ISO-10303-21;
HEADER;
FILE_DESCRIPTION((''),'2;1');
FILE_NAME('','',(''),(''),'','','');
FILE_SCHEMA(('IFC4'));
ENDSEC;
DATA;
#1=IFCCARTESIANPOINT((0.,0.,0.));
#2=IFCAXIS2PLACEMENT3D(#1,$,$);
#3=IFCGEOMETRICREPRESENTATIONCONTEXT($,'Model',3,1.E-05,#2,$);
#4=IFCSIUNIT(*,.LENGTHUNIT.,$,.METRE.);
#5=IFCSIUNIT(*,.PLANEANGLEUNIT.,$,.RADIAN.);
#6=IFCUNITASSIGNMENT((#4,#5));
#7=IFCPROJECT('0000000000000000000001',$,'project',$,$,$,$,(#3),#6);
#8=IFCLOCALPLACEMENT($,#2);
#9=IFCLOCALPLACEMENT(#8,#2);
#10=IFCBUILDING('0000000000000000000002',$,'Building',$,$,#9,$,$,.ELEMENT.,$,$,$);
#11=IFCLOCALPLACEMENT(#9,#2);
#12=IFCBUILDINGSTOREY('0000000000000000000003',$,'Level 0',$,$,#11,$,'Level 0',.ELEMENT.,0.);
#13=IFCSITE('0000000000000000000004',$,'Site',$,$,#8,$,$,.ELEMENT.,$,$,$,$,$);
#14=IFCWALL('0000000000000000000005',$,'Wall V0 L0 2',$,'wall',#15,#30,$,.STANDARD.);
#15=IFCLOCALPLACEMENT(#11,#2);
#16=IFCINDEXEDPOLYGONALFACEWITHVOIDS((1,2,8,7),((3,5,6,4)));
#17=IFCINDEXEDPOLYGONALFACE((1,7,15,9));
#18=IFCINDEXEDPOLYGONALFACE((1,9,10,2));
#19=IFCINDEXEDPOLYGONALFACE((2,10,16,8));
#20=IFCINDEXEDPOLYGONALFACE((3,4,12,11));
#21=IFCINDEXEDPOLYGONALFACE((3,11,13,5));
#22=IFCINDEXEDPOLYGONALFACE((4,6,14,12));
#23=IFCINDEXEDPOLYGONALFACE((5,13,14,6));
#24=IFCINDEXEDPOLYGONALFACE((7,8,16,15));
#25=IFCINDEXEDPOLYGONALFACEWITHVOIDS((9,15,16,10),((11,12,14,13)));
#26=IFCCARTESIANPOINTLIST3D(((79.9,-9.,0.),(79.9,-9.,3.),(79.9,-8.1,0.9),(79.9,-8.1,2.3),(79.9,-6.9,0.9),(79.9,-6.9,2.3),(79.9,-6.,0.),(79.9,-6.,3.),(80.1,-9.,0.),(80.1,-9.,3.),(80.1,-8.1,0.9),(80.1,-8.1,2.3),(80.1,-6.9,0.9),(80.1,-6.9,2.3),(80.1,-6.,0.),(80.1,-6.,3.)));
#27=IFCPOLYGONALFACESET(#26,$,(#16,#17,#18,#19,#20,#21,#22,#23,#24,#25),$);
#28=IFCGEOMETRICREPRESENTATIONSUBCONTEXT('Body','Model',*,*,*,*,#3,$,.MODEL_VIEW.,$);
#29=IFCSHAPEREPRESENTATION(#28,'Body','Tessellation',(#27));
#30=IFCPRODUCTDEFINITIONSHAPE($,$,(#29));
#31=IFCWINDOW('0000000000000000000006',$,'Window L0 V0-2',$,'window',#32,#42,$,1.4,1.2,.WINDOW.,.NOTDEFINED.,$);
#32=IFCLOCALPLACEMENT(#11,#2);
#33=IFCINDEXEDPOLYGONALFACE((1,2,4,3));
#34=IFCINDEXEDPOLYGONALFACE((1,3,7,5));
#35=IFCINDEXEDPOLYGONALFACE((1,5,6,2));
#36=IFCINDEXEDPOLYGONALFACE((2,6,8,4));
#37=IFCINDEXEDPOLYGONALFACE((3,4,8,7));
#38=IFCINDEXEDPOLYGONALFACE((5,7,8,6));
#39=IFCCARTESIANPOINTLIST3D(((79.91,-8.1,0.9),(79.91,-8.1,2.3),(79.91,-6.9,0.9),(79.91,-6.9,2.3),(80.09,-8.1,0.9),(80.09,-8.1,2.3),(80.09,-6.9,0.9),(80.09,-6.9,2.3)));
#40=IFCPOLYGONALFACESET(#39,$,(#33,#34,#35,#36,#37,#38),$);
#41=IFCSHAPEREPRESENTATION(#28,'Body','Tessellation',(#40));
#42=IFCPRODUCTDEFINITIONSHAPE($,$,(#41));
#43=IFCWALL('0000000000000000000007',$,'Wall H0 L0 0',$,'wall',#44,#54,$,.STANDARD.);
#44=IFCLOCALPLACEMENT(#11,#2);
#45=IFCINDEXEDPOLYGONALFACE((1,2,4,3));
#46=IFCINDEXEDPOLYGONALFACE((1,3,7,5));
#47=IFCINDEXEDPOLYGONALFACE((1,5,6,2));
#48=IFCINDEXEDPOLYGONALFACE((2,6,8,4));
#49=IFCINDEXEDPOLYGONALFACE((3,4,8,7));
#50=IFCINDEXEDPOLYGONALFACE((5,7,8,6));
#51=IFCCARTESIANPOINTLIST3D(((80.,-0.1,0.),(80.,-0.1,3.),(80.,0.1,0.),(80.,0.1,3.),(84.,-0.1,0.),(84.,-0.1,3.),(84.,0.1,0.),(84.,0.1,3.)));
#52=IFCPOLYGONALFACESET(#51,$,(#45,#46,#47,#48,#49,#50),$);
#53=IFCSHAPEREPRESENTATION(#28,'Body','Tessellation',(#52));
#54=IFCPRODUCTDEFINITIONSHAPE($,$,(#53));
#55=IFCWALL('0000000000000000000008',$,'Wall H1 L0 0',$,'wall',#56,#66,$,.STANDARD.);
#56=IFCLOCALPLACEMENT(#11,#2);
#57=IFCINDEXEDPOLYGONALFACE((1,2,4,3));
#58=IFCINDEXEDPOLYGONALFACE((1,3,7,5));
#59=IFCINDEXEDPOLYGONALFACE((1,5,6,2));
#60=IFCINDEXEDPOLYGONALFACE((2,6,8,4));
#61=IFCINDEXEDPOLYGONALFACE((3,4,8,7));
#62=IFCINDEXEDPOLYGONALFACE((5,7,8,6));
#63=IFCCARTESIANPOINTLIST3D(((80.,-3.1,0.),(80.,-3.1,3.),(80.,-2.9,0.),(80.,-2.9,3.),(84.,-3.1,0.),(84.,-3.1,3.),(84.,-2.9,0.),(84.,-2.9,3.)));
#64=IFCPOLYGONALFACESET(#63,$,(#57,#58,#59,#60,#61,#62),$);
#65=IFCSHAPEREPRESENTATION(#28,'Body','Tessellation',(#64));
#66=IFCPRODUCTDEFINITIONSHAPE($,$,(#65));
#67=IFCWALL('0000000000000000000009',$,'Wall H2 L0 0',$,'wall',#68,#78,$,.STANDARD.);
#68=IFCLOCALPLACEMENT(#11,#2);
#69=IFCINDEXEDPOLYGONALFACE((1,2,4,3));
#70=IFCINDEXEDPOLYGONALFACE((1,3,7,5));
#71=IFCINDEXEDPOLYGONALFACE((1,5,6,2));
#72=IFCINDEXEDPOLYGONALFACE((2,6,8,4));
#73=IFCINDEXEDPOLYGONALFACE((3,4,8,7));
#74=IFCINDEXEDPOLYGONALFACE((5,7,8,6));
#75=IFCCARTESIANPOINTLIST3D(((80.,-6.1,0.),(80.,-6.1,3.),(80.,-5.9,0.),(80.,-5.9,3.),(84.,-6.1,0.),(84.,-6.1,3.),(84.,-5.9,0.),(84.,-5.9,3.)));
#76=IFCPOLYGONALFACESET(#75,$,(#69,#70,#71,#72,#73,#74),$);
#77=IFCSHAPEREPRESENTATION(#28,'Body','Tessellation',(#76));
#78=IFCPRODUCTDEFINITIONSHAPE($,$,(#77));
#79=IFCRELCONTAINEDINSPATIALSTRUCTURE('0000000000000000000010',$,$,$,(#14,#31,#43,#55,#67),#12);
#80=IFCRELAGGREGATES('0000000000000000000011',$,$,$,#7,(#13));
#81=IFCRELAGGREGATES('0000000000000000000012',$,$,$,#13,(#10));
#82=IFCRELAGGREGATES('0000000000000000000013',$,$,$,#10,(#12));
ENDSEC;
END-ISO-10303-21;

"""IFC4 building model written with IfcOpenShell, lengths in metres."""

from ifc_helpers import new_model, si_unit, frame, frame_2d, origin, origin_2d, place, context, subcontext, project, spatial, rectangle, extrude, element, fill, save


model = new_model("IFC4")

# Units and contexts
model_context = context("Model", 3, precision=1e-05, world=origin())
body_context = subcontext(model_context, "Body", "Model", "MODEL_VIEW")
ifc_project = project(units=[si_unit("LENGTHUNIT", "METRE"), si_unit("PLANEANGLEUNIT", "RADIAN")], contexts=[model_context])

# Site, building, storey
site_placement = place(None, origin())
site = spatial("IfcSite", under=ifc_project, at=site_placement, Name="Site", CompositionType="ELEMENT")
building_placement = place(site_placement, origin())
building = spatial("IfcBuilding", under=site, at=building_placement, Name="Building", CompositionType="ELEMENT")
storey_placement = place(building_placement, origin())
storey = spatial("IfcBuildingStorey", under=building, at=storey_placement, Name="Level 0", LongName="Level 0", CompositionType="ELEMENT", Elevation=0.0)

# Wall, opening, window
wall_1_placement = place(storey_placement, frame((80.0, -6.0, 0.0), z_axis=(0.0, 0.0, 1.0), x_axis=(0.0, -1.0, 0.0)))
wall_1 = element("IfcWall", 1, at=wall_1_placement, inside=storey, Name="Wall V0 L0 2", ObjectType="wall", PredefinedType="STANDARD", context=body_context, shape_type="SweptSolid", body=[
    extrude(rectangle(XDim=3.0, YDim=0.2, at=frame_2d((1.5, 0.0))), origin(), (0.0, 0.0, 1.0), 3.0),
])
opening_1_placement = place(storey_placement, frame((80.0, -7.5, 0.9), z_axis=(0.0, 0.0, 1.0), x_axis=(0.0, -1.0, 0.0)))
opening_1 = element("IfcOpeningElement", 2, at=opening_1_placement, cuts=wall_1, ObjectType="Opening", PredefinedType="OPENING", context=body_context, shape_type="SweptSolid", body=[
    extrude(rectangle(XDim=1.2, YDim=0.22, at=origin_2d()), origin(), (0.0, 0.0, 1.0), 1.4),
])
window_1_placement = place(storey_placement, frame((80.0, -7.5, 0.9), z_axis=(0.0, 0.0, 1.0), x_axis=(0.0, -1.0, 0.0)))
window_1 = element("IfcWindow", 3, at=window_1_placement, inside=storey, Name="Window L0 V0-2", ObjectType="window", OverallHeight=1.4, OverallWidth=1.2, PartitioningType="NOTDEFINED", PredefinedType="WINDOW", context=body_context, shape_type="SweptSolid", body=[
    extrude(rectangle(XDim=1.2, YDim=0.18, at=origin_2d()), origin(), (0.0, 0.0, 1.0), 1.4),
])
fill(opening_1, window_1)

# Walls
for number, where, z_axis, x_axis, name in (
    (4, (80.0, 0.0, 0.0), (0.0, 0.0, 1.0), (1.0, 0.0, 0.0), "Wall H0 L0 0"),
    (5, (80.0, -3.0, 0.0), (0.0, 0.0, 1.0), (1.0, 0.0, 0.0), "Wall H1 L0 0"),
    (6, (80.0, -6.0, 0.0), (0.0, 0.0, 1.0), (1.0, 0.0, 0.0), "Wall H2 L0 0"),
):
    element("IfcWall", number, at=place(storey_placement, frame(where, z_axis=z_axis, x_axis=x_axis)), inside=storey, Name=name, ObjectType="wall", PredefinedType="STANDARD", context=body_context, shape_type="SweptSolid", body=[
        extrude(rectangle(XDim=4.0, YDim=0.2, at=frame_2d((2.0, 0.0))), origin(), (0.0, 0.0, 1.0), 3.0),
    ])

save(model, "model.ifc")
